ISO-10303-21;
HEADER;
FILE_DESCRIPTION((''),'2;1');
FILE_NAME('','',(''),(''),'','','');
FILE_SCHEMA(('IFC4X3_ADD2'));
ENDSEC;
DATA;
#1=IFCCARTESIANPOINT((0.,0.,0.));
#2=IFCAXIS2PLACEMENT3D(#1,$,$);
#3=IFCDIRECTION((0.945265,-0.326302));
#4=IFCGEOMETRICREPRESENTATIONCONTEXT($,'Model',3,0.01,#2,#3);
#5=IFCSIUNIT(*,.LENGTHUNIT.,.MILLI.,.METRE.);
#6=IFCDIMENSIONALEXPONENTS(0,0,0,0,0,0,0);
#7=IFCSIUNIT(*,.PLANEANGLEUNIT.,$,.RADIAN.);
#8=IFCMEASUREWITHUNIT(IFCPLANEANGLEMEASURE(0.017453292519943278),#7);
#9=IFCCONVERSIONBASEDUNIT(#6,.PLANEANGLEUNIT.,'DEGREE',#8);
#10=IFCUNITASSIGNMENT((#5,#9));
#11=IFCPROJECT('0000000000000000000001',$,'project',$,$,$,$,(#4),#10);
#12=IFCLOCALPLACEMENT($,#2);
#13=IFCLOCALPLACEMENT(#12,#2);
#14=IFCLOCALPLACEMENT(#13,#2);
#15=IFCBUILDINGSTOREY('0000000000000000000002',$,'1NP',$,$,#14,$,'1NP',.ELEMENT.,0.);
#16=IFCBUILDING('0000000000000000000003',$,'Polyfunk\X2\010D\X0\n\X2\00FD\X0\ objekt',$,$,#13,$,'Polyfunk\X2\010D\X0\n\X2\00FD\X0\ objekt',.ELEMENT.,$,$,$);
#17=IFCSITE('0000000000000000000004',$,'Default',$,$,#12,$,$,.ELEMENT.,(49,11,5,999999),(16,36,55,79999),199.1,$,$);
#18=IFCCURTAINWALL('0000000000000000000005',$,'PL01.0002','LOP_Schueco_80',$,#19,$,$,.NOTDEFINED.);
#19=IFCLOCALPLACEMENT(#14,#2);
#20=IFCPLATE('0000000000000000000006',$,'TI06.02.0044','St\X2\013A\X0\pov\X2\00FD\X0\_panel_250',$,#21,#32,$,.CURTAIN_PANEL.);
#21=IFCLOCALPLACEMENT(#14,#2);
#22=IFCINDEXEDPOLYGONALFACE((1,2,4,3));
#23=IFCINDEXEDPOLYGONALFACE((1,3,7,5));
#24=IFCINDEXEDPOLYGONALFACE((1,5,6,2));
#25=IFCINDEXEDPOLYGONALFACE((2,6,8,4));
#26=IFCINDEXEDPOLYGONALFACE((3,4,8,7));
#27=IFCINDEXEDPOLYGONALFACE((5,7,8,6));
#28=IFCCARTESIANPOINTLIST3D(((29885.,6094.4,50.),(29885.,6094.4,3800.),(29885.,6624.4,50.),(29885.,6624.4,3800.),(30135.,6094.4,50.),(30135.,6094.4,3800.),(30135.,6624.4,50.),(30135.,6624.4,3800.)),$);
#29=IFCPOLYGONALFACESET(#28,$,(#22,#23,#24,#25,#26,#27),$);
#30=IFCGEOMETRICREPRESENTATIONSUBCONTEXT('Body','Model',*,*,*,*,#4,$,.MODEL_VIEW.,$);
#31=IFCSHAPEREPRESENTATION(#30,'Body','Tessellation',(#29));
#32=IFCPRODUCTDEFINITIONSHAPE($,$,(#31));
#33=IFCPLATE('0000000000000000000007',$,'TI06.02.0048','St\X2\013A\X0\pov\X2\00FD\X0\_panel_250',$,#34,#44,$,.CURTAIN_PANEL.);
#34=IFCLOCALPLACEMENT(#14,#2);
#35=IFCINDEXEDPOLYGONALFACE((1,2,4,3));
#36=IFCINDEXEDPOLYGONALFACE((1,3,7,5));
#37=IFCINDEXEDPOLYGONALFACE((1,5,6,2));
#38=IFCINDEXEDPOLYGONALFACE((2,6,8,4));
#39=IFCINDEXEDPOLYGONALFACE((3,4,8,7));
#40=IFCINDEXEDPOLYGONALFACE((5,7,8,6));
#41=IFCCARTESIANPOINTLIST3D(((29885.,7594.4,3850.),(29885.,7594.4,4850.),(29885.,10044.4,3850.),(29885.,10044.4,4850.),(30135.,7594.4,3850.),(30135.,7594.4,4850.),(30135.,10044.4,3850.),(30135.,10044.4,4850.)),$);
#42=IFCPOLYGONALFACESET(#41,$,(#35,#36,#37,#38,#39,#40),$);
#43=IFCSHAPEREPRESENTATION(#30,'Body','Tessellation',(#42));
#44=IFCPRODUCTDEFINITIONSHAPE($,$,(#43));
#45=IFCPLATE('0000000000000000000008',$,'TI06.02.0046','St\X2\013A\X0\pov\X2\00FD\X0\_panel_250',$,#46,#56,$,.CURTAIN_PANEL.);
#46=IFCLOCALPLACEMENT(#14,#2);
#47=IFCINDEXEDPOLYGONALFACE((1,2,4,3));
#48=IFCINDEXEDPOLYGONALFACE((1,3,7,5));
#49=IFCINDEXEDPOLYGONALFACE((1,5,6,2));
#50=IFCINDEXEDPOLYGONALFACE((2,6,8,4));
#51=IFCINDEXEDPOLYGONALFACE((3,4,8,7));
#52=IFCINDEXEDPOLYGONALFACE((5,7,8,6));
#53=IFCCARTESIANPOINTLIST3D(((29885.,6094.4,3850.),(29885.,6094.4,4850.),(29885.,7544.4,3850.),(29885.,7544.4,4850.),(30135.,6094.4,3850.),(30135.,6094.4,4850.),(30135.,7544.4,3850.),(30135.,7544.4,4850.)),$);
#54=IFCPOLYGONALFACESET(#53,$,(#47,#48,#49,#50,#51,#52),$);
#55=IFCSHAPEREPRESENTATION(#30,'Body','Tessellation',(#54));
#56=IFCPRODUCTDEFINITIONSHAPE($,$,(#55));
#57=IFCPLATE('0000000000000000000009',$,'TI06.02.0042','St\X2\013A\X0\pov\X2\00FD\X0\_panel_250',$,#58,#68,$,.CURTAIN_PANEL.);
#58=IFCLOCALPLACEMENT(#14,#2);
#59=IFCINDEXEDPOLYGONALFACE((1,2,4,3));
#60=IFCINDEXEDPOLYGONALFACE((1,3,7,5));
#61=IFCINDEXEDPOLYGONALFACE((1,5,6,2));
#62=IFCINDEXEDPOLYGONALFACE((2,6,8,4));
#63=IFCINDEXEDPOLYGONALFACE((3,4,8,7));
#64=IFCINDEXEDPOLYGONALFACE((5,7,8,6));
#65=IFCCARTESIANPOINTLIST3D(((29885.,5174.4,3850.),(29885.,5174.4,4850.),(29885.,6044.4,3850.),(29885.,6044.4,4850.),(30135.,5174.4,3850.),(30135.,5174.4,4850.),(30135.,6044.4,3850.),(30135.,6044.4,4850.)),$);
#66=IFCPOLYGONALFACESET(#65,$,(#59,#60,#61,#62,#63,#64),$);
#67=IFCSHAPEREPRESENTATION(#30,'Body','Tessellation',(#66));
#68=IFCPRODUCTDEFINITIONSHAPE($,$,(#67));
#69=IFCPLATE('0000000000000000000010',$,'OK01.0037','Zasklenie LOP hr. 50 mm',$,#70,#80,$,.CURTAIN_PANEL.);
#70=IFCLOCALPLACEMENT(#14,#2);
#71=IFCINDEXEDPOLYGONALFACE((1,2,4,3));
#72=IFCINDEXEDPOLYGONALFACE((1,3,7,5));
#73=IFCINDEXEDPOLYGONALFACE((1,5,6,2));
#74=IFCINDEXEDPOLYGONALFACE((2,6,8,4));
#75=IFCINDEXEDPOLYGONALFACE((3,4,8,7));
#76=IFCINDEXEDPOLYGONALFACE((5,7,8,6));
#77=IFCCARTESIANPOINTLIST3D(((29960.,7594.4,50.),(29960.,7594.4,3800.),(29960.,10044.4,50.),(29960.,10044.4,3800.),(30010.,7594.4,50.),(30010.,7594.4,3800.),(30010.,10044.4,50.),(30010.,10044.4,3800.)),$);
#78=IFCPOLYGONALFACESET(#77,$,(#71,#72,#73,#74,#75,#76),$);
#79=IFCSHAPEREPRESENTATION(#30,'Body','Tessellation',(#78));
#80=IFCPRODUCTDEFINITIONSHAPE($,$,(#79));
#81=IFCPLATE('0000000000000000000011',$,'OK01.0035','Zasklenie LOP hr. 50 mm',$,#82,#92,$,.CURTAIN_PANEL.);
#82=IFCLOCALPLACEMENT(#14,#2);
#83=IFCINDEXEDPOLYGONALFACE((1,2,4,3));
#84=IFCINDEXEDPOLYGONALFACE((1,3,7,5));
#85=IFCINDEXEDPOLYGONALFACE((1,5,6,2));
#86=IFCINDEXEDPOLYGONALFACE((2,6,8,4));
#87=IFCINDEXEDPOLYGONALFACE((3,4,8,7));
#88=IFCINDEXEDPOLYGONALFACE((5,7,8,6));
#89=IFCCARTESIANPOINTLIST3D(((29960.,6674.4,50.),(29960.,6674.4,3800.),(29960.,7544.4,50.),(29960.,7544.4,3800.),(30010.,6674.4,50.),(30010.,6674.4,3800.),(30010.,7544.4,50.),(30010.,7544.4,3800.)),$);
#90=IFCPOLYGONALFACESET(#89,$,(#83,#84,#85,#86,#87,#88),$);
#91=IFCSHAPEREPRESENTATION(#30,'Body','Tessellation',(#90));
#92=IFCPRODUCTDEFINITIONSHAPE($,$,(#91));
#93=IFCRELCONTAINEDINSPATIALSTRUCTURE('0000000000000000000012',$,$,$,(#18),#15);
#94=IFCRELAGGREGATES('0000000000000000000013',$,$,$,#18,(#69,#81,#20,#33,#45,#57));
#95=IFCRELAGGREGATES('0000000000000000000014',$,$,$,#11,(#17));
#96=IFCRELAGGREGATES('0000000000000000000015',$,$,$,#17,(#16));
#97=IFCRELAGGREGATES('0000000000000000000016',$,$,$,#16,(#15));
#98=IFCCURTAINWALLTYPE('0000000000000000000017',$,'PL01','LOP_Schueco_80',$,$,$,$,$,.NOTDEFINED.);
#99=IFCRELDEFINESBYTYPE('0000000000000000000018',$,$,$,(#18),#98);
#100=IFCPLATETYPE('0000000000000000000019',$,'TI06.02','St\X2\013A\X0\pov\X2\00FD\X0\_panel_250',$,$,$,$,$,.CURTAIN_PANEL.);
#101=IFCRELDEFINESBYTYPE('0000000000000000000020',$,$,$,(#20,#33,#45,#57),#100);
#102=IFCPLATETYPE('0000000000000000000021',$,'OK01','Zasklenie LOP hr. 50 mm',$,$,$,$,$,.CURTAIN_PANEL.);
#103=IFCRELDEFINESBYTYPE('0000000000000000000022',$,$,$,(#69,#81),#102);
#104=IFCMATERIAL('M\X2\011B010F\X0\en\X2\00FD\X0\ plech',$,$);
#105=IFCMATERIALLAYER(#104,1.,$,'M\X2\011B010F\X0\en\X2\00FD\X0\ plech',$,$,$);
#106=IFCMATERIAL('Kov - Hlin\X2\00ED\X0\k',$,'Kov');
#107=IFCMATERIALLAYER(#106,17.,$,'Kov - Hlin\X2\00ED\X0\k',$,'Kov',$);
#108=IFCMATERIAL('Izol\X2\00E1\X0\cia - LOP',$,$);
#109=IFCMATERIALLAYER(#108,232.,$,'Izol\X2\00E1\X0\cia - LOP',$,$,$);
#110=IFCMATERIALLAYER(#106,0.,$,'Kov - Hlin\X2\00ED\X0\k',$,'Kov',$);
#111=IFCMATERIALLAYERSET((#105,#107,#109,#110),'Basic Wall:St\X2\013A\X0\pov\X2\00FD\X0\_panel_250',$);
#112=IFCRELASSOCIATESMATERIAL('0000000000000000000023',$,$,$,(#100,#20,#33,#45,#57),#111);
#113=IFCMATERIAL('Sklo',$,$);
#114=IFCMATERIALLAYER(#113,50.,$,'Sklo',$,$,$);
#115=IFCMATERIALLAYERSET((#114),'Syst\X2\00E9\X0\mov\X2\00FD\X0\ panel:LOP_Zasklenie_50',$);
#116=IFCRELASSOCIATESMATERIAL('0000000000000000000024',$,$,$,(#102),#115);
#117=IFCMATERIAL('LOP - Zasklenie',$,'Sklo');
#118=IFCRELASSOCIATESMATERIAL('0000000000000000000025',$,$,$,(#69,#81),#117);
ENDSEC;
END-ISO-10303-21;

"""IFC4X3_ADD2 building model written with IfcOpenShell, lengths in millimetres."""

from ifc_helpers import new_model, entity, si_unit, converted_unit, direction, frame, frame_2d, origin, place, context, subcontext, project, spatial, rectangle, extrude, source, transform, mapped, material, layer, layer_set, layer_usage, type_object, type_shapes, element, aggregate, save


model = new_model("IFC4X3_ADD2")

# Units and contexts
model_context = context("Model", 3, precision=0.01, world=origin(), true_north=direction((0.945265, -0.326302)))
body_context = subcontext(model_context, "Body", "Model", "MODEL_VIEW")
ifc_project = project(units=[si_unit("LENGTHUNIT", "METRE", prefix="MILLI"), converted_unit("PLANEANGLEUNIT", "DEGREE", entity("IfcPlaneAngleMeasure", 0.017453292519943278), si_unit("PLANEANGLEUNIT", "RADIAN"), dimensions=[0, 0, 0, 0, 0, 0, 0])], contexts=[model_context])

# Site, building, storey
site_placement = place(None, origin())
site = spatial("IfcSite", under=ifc_project, at=site_placement, Name="Default", CompositionType="ELEMENT", RefLatitude=(49, 11, 5, 999999), RefLongitude=(16, 36, 55, 79999), RefElevation=199.1)
building_placement = place(site_placement, origin())
building = spatial("IfcBuilding", under=site, at=building_placement, Name="Polyfunkčný objekt", LongName="Polyfunkčný objekt", CompositionType="ELEMENT")
storey_placement = place(building_placement, origin())
storey = spatial("IfcBuildingStorey", under=building, at=storey_placement, Name="1NP", LongName="1NP", CompositionType="ELEMENT", Elevation=0.0)

# Curtain wall, plates
curtain_wall_type = type_object("IfcCurtainWallType", Name="PL01", Description="LOP_Schueco_80", PredefinedType="NOTDEFINED")
curtain_wall_placement = place(storey_placement, origin())
curtain_wall = element("IfcCurtainWall", 1, at=curtain_wall_placement, inside=storey, type_object=curtain_wall_type, Name="PL01.0002", Description="LOP_Schueco_80", PredefinedType="NOTDEFINED")
ifc_material_1 = material(Name="Měďený plech")
ifc_layer_1 = layer(ifc_material_1, 1.0, Name="Měďený plech")
ifc_material_2 = material(Name="Kov - Hliník", Category="Kov")
ifc_layer_2 = layer(ifc_material_2, 17.0, Name="Kov - Hliník", Category="Kov")
ifc_material_3 = material(Name="Izolácia - LOP")
ifc_layer_3 = layer(ifc_material_3, 232.0, Name="Izolácia - LOP")
ifc_layer_4 = layer(ifc_material_2, 0.0, Name="Kov - Hliník", Category="Kov")
ifc_layer_set_1 = layer_set([ifc_layer_1, ifc_layer_2, ifc_layer_3, ifc_layer_4], Name="Basic Wall:Stĺpový_panel_250")
ifc_layer_usage_1 = layer_usage(ifc_layer_set_1, "AXIS2", "POSITIVE", -125.0)
plate_type_1 = type_object("IfcPlateType", Name="TI06.02", Description="Stĺpový_panel_250", PredefinedType="CURTAIN_PANEL", material=ifc_layer_set_1)
plate_1_placement = place(storey_placement, frame((30010.0, 6624.4, 50.0), z_axis=(0.0, 0.0, 1.0), x_axis=(0.0, -1.0, 0.0)))
plate_1 = element("IfcPlate", 2, at=plate_1_placement, type_object=plate_type_1, material=ifc_layer_usage_1, Name="TI06.02.0044", Description="Stĺpový_panel_250", PredefinedType="CURTAIN_PANEL", context=body_context, shape_type="SweptSolid", body=[
    extrude(rectangle(XDim=250.0, YDim=530.0, at=frame_2d((0.0, 0.0), x_axis=(1.0, 0.0))), frame((265.0, 0.0, 0.0), z_axis=(0.0, 0.0, 1.0), x_axis=(0.0, 1.0, 0.0)), (0.0, 0.0, 1.0), 3750.0),
])
ifc_layer_usage_2 = layer_usage(ifc_layer_set_1, "AXIS2", "POSITIVE", -125.0)
plate_2_placement = place(storey_placement, frame((30010.0, 10044.4, 3850.0), z_axis=(0.0, 0.0, 1.0), x_axis=(0.0, -1.0, 0.0)))
plate_2 = element("IfcPlate", 3, at=plate_2_placement, type_object=plate_type_1, material=ifc_layer_usage_2, Name="TI06.02.0048", Description="Stĺpový_panel_250", PredefinedType="CURTAIN_PANEL", context=body_context, shape_type="SweptSolid", body=[
    extrude(rectangle(XDim=250.0, YDim=2450.0, at=frame_2d((0.0, 0.0), x_axis=(1.0, 0.0))), frame((1225.0, 0.0, 0.0), z_axis=(0.0, 0.0, 1.0), x_axis=(0.0, 1.0, 0.0)), (0.0, 0.0, 1.0), 1000.0),
])
ifc_layer_usage_3 = layer_usage(ifc_layer_set_1, "AXIS2", "POSITIVE", -125.0)
plate_3_placement = place(storey_placement, frame((30010.0, 7544.4, 3850.0), z_axis=(0.0, 0.0, 1.0), x_axis=(0.0, -1.0, 0.0)))
plate_3 = element("IfcPlate", 4, at=plate_3_placement, type_object=plate_type_1, material=ifc_layer_usage_3, Name="TI06.02.0046", Description="Stĺpový_panel_250", PredefinedType="CURTAIN_PANEL", context=body_context, shape_type="SweptSolid", body=[
    extrude(rectangle(XDim=250.0, YDim=1450.0, at=frame_2d((0.0, 0.0), x_axis=(1.0, 0.0))), frame((725.0, 0.0, 0.0), z_axis=(0.0, 0.0, 1.0), x_axis=(0.0, 1.0, 0.0)), (0.0, 0.0, 1.0), 1000.0),
])
ifc_layer_usage_4 = layer_usage(ifc_layer_set_1, "AXIS2", "POSITIVE", -125.0)
plate_4_placement = place(storey_placement, frame((30010.0, 6044.4, 3850.0), z_axis=(0.0, 0.0, 1.0), x_axis=(0.0, -1.0, 0.0)))
plate_4 = element("IfcPlate", 5, at=plate_4_placement, type_object=plate_type_1, material=ifc_layer_usage_4, Name="TI06.02.0042", Description="Stĺpový_panel_250", PredefinedType="CURTAIN_PANEL", context=body_context, shape_type="SweptSolid", body=[
    extrude(rectangle(XDim=250.0, YDim=870.0, at=frame_2d((0.0, 0.0), x_axis=(1.0, 0.0))), frame((435.0, 0.0, 0.0), z_axis=(0.0, 0.0, 1.0), x_axis=(0.0, 1.0, 0.0)), (0.0, 0.0, 1.0), 1000.0),
])
ifc_material_4 = material(Name="LOP - Zasklenie", Category="Sklo")
ifc_material_5 = material(Name="Sklo")
ifc_layer_5 = layer(ifc_material_5, 50.0, Name="Sklo")
ifc_layer_set_2 = layer_set([ifc_layer_5], Name="Systémový panel:LOP_Zasklenie_50")
plate_type_2 = type_object("IfcPlateType", Name="OK01", Description="Zasklenie LOP hr. 50 mm", PredefinedType="CURTAIN_PANEL", material=ifc_layer_set_2)
shared_shape_1 = source(origin(), body_context, "Body", "SweptSolid", [
    extrude(rectangle(XDim=3750.0, YDim=2450.0, at=frame_2d((-141.7, 0.0), x_axis=(1.0, 0.0))), frame((0.0, -50.0, 2016.7), z_axis=(0.0, 1.0, 0.0), x_axis=(0.0, 0.0, 1.0)), (0.0, 0.0, 1.0), 50.0),
])
plate_5_placement = place(curtain_wall_placement, frame((30010.0, 8819.4, 50.0), z_axis=(0.0, 0.0, 1.0), x_axis=(0.0, -1.0, 0.0)))
plate_5 = element("IfcPlate", 6, at=plate_5_placement, type_object=plate_type_2, material=ifc_material_4, Name="OK01.0037", Description="Zasklenie LOP hr. 50 mm", PredefinedType="CURTAIN_PANEL", context=body_context, shape_type="MappedRepresentation", body=[
    mapped(shared_shape_1, transform((0.0, 0.0, 0.0), scale=1.0)),
])
shared_shape_2 = source(origin(), body_context, "Body", "SweptSolid", [
    extrude(rectangle(XDim=3750.0, YDim=870.0, at=frame_2d((-141.7, 0.0), x_axis=(1.0, 0.0))), frame((0.0, -50.0, 2016.7), z_axis=(0.0, 1.0, 0.0), x_axis=(0.0, 0.0, 1.0)), (0.0, 0.0, 1.0), 50.0),
])
type_shapes(plate_type_2, [shared_shape_1, shared_shape_2])
plate_6_placement = place(curtain_wall_placement, frame((30010.0, 7109.4, 50.0), z_axis=(0.0, 0.0, 1.0), x_axis=(0.0, -1.0, 0.0)))
plate_6 = element("IfcPlate", 7, at=plate_6_placement, type_object=plate_type_2, material=ifc_material_4, Name="OK01.0035", Description="Zasklenie LOP hr. 50 mm", PredefinedType="CURTAIN_PANEL", context=body_context, shape_type="MappedRepresentation", body=[
    mapped(shared_shape_2, transform((0.0, 0.0, 0.0), scale=1.0)),
])
aggregate(curtain_wall, [plate_5, plate_6, plate_1, plate_2, plate_3, plate_4])

save(model, "model.ifc")
